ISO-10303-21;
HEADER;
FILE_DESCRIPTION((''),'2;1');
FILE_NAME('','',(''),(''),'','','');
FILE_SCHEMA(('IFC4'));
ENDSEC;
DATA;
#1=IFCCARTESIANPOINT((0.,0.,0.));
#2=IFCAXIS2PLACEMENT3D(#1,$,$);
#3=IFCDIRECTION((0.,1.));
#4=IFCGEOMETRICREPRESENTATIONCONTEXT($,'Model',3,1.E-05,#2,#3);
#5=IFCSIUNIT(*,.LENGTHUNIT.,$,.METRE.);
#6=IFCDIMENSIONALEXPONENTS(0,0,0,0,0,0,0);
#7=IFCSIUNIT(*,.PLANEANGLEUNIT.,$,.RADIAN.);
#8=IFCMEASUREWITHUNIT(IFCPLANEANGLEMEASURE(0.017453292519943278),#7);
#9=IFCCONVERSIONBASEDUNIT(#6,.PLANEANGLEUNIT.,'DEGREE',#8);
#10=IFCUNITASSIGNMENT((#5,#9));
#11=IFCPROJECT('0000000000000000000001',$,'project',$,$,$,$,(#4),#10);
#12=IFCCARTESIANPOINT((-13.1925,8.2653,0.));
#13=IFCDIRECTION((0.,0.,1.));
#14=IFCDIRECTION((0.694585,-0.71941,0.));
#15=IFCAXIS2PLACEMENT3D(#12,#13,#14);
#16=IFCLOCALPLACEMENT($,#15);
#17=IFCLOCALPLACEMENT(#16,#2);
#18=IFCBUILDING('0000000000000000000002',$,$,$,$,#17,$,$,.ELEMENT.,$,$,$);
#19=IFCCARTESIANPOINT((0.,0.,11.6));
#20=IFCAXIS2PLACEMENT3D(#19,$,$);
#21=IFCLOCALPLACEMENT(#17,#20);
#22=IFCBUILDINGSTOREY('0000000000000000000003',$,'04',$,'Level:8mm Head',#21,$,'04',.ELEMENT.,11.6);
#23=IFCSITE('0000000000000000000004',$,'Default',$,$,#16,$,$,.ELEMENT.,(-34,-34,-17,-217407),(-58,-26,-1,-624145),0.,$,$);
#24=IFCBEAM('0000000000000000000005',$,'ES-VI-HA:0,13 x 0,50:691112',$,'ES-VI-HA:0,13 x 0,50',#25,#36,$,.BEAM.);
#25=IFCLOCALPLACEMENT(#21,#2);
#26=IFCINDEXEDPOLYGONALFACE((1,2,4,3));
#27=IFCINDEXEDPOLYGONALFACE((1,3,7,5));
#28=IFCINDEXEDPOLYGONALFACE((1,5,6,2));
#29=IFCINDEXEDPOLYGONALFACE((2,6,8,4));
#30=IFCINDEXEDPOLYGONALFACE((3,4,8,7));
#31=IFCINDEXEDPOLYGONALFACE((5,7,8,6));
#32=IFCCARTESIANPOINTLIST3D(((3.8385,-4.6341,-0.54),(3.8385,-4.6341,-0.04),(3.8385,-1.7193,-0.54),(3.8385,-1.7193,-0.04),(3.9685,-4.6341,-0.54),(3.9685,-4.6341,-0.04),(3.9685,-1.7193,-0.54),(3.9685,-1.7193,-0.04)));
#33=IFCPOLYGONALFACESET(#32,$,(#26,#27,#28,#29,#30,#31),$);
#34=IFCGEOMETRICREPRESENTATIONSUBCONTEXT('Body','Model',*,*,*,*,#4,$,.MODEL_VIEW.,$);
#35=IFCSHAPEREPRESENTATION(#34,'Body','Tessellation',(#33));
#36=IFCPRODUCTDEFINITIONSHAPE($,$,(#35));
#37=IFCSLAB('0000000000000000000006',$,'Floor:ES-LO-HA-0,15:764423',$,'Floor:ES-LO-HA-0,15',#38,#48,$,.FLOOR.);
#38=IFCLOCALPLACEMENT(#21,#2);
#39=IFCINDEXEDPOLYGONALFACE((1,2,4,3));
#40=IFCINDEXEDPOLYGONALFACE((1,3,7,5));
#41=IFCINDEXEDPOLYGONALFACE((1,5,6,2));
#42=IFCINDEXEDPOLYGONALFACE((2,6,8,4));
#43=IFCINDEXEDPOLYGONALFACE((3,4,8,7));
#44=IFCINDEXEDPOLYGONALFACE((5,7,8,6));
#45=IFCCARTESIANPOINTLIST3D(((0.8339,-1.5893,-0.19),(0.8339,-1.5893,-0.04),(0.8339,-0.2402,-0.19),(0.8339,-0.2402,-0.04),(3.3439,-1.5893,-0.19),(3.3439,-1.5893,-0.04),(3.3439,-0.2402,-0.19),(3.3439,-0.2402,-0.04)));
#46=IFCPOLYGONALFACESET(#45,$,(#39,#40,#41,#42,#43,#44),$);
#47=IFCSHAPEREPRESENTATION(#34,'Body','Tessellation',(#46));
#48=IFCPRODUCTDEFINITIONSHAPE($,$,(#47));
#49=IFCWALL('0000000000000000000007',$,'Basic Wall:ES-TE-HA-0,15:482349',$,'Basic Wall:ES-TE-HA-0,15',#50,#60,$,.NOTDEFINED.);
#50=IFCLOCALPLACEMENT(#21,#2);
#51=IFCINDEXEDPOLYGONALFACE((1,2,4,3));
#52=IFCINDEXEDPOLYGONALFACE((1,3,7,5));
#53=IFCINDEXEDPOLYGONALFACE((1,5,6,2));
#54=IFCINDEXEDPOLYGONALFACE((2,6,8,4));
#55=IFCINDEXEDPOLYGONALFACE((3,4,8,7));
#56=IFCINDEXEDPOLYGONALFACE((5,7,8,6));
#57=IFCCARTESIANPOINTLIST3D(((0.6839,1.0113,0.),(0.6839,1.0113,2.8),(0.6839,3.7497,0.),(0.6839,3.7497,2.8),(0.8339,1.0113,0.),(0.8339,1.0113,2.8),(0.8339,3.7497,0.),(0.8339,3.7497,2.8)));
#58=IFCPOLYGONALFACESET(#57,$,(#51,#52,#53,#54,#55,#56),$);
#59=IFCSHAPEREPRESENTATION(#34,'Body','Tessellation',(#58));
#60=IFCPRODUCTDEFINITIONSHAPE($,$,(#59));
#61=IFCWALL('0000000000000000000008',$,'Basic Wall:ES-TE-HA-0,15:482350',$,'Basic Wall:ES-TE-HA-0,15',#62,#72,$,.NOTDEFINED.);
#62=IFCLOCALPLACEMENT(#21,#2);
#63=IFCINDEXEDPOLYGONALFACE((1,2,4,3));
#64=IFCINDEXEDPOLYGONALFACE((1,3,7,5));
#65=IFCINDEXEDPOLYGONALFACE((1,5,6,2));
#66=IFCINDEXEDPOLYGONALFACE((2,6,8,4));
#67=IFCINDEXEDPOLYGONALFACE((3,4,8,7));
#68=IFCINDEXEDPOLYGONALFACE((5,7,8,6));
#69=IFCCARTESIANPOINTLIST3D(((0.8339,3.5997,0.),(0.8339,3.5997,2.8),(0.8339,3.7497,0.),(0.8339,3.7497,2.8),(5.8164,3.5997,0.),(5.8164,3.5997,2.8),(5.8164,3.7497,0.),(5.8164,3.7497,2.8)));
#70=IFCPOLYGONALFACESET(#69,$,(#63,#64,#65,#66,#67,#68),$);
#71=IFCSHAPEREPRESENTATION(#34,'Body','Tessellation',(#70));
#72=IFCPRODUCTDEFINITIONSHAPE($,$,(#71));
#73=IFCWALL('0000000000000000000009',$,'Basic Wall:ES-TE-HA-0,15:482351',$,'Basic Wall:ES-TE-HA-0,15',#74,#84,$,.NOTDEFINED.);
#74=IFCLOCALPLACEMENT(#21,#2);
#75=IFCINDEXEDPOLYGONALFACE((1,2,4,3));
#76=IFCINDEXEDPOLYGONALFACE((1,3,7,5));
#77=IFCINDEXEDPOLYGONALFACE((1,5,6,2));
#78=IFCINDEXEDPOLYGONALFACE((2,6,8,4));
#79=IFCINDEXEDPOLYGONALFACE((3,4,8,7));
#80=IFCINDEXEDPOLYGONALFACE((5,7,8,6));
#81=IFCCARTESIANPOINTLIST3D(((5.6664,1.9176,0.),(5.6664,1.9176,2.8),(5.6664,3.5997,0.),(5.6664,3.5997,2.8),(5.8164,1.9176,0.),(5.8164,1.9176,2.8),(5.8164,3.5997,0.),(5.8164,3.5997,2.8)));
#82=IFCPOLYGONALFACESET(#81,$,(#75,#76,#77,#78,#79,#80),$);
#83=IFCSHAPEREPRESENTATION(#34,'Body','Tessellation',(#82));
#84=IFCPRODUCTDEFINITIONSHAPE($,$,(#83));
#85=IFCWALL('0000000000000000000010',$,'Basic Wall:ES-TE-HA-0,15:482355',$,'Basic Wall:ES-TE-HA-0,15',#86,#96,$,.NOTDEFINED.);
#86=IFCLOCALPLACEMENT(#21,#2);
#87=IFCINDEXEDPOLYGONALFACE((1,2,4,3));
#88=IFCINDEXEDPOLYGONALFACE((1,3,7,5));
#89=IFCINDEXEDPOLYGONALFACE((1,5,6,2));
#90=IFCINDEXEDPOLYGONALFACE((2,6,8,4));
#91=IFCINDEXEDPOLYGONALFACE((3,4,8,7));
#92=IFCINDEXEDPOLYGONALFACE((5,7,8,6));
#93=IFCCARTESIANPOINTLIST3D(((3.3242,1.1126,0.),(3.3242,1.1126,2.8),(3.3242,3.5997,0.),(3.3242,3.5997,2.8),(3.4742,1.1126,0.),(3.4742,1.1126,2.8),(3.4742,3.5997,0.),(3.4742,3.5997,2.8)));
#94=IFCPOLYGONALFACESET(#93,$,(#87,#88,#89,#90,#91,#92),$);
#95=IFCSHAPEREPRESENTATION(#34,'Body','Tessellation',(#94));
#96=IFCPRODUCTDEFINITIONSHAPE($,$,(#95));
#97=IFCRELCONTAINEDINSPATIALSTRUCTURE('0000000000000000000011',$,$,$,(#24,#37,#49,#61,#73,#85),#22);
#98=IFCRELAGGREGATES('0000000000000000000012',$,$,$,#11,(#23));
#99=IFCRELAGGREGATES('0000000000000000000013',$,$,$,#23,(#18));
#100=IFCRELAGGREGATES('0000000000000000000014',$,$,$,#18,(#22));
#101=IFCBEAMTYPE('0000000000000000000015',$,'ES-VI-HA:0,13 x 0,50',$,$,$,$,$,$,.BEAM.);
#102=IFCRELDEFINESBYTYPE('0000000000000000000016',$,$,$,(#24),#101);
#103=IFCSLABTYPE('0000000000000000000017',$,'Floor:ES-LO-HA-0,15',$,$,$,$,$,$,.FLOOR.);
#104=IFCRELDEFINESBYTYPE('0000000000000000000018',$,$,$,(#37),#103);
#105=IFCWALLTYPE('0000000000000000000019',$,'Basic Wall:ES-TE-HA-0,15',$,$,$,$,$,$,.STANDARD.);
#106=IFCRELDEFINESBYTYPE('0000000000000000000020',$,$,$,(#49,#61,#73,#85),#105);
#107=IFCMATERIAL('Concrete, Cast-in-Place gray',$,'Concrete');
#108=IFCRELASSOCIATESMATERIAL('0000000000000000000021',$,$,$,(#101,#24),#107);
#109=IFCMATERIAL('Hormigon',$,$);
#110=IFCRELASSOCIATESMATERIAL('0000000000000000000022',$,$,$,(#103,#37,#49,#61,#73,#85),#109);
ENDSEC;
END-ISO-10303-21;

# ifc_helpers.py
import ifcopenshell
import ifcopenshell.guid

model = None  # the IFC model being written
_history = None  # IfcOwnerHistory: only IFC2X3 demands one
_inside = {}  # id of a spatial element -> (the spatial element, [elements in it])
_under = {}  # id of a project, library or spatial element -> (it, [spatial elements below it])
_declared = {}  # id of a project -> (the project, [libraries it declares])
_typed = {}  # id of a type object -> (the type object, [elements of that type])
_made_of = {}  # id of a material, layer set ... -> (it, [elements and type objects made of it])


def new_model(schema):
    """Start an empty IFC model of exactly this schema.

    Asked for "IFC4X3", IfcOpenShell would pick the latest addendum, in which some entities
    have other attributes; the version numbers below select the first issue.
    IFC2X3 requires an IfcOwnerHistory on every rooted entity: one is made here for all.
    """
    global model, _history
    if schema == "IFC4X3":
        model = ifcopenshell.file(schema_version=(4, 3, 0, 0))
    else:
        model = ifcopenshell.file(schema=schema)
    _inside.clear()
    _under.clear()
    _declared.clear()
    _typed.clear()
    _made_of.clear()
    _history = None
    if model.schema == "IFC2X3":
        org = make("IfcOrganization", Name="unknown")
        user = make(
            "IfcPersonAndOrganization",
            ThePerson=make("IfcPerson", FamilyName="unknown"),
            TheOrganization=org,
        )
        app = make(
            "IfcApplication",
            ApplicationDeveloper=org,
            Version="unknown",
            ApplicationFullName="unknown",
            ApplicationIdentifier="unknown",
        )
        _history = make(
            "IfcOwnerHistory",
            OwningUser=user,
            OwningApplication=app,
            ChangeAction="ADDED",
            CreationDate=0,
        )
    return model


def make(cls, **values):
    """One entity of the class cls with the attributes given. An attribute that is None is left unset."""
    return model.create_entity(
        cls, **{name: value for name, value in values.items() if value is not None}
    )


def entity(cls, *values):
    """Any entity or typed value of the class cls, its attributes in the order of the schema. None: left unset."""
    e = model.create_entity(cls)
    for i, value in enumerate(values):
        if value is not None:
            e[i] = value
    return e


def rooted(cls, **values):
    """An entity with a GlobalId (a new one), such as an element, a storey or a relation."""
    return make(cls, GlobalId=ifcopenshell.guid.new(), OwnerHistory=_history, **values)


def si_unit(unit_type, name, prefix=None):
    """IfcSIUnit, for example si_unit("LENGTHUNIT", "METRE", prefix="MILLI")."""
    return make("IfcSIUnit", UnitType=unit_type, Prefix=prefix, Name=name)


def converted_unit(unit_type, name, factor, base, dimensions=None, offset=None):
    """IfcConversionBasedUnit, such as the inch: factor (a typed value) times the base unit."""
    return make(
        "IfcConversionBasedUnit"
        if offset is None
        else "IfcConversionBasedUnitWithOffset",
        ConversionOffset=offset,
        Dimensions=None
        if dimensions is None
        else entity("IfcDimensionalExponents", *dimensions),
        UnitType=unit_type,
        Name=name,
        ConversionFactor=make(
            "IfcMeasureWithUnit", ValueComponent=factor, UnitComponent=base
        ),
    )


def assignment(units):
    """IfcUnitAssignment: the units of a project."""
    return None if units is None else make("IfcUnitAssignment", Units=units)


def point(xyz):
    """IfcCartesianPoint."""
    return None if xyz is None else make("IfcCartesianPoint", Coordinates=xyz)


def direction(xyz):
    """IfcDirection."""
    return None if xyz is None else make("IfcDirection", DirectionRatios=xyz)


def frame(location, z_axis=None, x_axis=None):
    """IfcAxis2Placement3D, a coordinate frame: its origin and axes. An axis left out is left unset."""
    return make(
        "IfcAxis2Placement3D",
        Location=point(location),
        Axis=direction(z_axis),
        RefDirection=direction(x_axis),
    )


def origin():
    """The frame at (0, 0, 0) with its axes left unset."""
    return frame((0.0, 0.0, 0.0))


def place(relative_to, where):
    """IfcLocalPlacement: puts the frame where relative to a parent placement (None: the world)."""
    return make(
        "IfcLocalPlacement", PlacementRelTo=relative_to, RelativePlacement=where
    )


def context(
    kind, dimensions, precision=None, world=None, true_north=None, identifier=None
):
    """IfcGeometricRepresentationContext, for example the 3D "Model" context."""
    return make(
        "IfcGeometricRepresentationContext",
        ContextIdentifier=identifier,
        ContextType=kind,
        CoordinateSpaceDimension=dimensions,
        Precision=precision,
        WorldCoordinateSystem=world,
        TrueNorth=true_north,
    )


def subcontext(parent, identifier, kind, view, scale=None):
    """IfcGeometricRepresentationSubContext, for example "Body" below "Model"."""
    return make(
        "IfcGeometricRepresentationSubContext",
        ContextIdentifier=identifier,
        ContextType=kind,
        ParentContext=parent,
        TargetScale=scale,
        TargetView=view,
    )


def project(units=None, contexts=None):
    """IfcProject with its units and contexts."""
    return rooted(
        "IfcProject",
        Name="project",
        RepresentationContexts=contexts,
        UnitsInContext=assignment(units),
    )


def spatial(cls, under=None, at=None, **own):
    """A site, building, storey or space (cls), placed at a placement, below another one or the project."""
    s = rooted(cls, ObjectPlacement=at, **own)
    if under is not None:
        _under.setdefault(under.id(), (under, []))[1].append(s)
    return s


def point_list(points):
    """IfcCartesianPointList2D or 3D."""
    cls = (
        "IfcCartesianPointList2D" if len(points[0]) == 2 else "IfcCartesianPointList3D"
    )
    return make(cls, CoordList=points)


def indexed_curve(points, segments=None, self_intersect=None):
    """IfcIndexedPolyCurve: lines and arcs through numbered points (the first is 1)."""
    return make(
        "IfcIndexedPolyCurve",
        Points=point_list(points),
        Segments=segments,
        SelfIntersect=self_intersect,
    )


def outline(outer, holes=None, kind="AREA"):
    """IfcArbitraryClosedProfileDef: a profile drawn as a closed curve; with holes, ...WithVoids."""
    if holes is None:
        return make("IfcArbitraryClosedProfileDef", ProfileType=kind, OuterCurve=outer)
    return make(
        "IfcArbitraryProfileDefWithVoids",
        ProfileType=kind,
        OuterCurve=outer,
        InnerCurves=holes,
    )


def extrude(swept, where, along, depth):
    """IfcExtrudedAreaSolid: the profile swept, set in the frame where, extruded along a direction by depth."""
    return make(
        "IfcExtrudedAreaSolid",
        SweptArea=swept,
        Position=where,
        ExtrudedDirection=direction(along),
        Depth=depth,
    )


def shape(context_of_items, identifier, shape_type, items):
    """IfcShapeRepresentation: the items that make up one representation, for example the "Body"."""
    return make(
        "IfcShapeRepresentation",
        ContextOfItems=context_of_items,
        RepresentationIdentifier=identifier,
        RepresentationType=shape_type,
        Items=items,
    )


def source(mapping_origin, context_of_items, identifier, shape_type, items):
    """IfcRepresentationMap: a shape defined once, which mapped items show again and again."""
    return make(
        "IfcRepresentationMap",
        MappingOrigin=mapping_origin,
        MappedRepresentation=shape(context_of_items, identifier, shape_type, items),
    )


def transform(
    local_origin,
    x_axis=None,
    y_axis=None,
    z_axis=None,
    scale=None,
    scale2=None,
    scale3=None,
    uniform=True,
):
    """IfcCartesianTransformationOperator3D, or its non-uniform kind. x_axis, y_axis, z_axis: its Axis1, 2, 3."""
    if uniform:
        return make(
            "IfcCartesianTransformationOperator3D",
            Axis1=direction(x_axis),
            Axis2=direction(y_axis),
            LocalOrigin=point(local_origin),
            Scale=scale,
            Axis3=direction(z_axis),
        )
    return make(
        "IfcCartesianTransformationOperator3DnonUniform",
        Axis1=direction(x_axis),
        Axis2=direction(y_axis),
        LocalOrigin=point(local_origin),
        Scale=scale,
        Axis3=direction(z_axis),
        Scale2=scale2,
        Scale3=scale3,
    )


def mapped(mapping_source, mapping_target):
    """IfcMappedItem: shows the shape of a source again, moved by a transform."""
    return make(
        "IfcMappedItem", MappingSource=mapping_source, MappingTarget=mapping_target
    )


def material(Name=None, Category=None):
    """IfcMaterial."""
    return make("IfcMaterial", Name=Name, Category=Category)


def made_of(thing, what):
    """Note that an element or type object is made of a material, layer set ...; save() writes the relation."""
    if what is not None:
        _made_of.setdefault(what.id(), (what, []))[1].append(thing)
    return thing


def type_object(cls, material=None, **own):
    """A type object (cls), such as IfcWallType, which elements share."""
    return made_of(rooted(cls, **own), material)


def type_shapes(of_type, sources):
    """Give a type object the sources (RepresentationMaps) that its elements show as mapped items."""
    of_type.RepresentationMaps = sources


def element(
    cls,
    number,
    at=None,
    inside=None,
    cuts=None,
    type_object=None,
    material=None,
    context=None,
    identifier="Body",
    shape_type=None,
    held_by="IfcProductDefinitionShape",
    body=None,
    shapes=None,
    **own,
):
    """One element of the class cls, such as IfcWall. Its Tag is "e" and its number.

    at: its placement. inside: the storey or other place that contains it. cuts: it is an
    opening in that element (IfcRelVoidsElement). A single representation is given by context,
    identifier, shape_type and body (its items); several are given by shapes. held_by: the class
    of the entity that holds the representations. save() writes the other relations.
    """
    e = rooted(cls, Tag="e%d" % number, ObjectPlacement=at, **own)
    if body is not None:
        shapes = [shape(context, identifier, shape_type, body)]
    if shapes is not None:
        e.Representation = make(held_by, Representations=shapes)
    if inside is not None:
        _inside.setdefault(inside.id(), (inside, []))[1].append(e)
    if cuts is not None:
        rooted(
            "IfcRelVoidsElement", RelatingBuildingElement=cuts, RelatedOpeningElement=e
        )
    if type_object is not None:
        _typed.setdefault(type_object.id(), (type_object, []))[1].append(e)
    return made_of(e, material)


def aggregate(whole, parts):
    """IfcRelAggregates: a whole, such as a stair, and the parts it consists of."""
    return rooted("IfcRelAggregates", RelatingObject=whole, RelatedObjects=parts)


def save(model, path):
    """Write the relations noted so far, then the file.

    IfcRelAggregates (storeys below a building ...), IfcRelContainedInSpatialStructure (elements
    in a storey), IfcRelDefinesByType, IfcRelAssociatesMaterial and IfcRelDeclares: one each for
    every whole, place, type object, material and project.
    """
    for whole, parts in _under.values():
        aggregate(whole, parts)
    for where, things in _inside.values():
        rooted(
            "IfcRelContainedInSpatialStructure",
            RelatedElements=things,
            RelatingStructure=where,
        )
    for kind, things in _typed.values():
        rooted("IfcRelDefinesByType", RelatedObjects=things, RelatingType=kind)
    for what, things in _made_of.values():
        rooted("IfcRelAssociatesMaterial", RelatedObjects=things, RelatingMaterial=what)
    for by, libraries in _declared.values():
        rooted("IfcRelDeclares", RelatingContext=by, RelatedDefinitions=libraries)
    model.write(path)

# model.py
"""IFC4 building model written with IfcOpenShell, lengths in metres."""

from ifc_helpers import new_model, entity, si_unit, converted_unit, direction, frame, origin, place, context, subcontext, project, spatial, indexed_curve, outline, extrude, source, transform, mapped, material, type_object, type_shapes, element, save


model = new_model("IFC4")

# Units and contexts
model_context = context("Model", 3, precision=1e-05, world=origin(), true_north=direction((0.0, 1.0)))
body_context = subcontext(model_context, "Body", "Model", "MODEL_VIEW")
ifc_project = project(units=[si_unit("LENGTHUNIT", "METRE"), converted_unit("PLANEANGLEUNIT", "DEGREE", entity("IfcPlaneAngleMeasure", 0.017453292519943278), si_unit("PLANEANGLEUNIT", "RADIAN"), dimensions=[0, 0, 0, 0, 0, 0, 0])], contexts=[model_context])

# Site, building, storey
site_placement = place(None, frame((-13.1925, 8.2653, 0.0), z_axis=(0.0, 0.0, 1.0), x_axis=(0.694585, -0.71941, 0.0)))
site = spatial("IfcSite", under=ifc_project, at=site_placement, Name="Default", CompositionType="ELEMENT", RefLatitude=(-34, -34, -17, -217407), RefLongitude=(-58, -26, -1, -624145), RefElevation=0.0)
building_placement = place(site_placement, origin())
building = spatial("IfcBuilding", under=site, at=building_placement, CompositionType="ELEMENT")
storey_placement = place(building_placement, frame((0.0, 0.0, 11.6)))
storey = spatial("IfcBuildingStorey", under=building, at=storey_placement, Name="04", ObjectType="Level:8mm Head", LongName="04", CompositionType="ELEMENT", Elevation=11.6)

# Beam
ifc_material_1 = material(Name="Concrete, Cast-in-Place gray", Category="Concrete")
beam_type = type_object("IfcBeamType", Name="ES-VI-HA:0,13 x 0,50", PredefinedType="BEAM", material=ifc_material_1)
shared_shape = source(origin(), body_context, "Body", "SweptSolid", [
    extrude(outline(indexed_curve([(-0.065, -0.25), (0.065, -0.25), (0.065, 0.25), (-0.065, 0.25), (-0.065, -0.25)], self_intersect=False)), frame((3.9035, -4.6341, 11.31), z_axis=(0.0, 1.0, 0.0), x_axis=(-1.0, 0.0, 0.0)), (0.0, 0.0, 1.0), 2.9148),
])
type_shapes(beam_type, [shared_shape])
beam_placement = place(storey_placement, frame((0.0, 0.0, -11.6)))
element("IfcBeam", 1, at=beam_placement, inside=storey, type_object=beam_type, material=ifc_material_1, Name="ES-VI-HA:0,13 x 0,50:691112", ObjectType="ES-VI-HA:0,13 x 0,50", PredefinedType="BEAM", context=body_context, shape_type="MappedRepresentation", body=[
    mapped(shared_shape, transform((0.0, 0.0, 0.0), scale=1.0)),
])

# Shared definitions
ifc_material_2 = material(Name="Hormigon")
slab_type_1 = type_object("IfcSlabType", Name="Floor:ES-LO-HA-0,15", PredefinedType="FLOOR", material=ifc_material_2)

# Slab
slab_1_placement = place(storey_placement, origin())
element("IfcSlab", 2, at=slab_1_placement, inside=storey, type_object=slab_type_1, material=ifc_material_2, Name="Floor:ES-LO-HA-0,15:764423", ObjectType="Floor:ES-LO-HA-0,15", PredefinedType="FLOOR", context=body_context, shape_type="SweptSolid", body=[
    extrude(outline(indexed_curve([(-0.6746, -1.255), (0.6746, -1.255), (0.6746, 1.255), (-0.6746, 1.255), (-0.6746, -1.255)], self_intersect=False)), frame((2.0889, -0.9147, -0.04), z_axis=(0.0, 0.0, -1.0), x_axis=(0.0, 1.0, 0.0)), (0.0, 0.0, 1.0), 0.15),
])

# Walls
wall_type = type_object("IfcWallType", Name="Basic Wall:ES-TE-HA-0,15", PredefinedType="STANDARD")
wall_1_placement = place(storey_placement, frame((0.7589, 1.0113, 0.0), z_axis=(0.0, 0.0, 1.0), x_axis=(0.0, 1.0, 0.0)))
element("IfcWall", 3, at=wall_1_placement, inside=storey, type_object=wall_type, material=ifc_material_2, Name="Basic Wall:ES-TE-HA-0,15:482349", ObjectType="Basic Wall:ES-TE-HA-0,15", PredefinedType="NOTDEFINED", context=body_context, shape_type="SweptSolid", body=[
    extrude(outline(indexed_curve([(2.7384, 0.075), (0.0, 0.075), (0.0, -0.075), (2.7384, -0.075), (2.7384, 0.075)], self_intersect=False)), origin(), (0.0, 0.0, 1.0), 2.8),
])
wall_2_placement = place(storey_placement, frame((0.8339, 3.6747, 0.0)))
element("IfcWall", 4, at=wall_2_placement, inside=storey, type_object=wall_type, material=ifc_material_2, Name="Basic Wall:ES-TE-HA-0,15:482350", ObjectType="Basic Wall:ES-TE-HA-0,15", PredefinedType="NOTDEFINED", context=body_context, shape_type="SweptSolid", body=[
    extrude(outline(indexed_curve([(4.9825, 0.075), (0.0, 0.075), (0.0, -0.075), (4.9825, -0.075), (4.9825, 0.075)], self_intersect=False)), origin(), (0.0, 0.0, 1.0), 2.8),
])
wall_3_placement = place(storey_placement, frame((5.7414, 1.9176, 0.0), z_axis=(0.0, 0.0, 1.0), x_axis=(0.0, 1.0, 0.0)))
element("IfcWall", 5, at=wall_3_placement, inside=storey, type_object=wall_type, material=ifc_material_2, Name="Basic Wall:ES-TE-HA-0,15:482351", ObjectType="Basic Wall:ES-TE-HA-0,15", PredefinedType="NOTDEFINED", context=body_context, shape_type="SweptSolid", body=[
    extrude(outline(indexed_curve([(1.682, 0.075), (0.0, 0.075), (0.0, -0.075), (1.682, -0.075), (1.682, 0.075)], self_intersect=False)), origin(), (0.0, 0.0, 1.0), 2.8),
])
wall_4_placement = place(storey_placement, frame((3.3992, 3.5997, 0.0), z_axis=(0.0, 0.0, 1.0), x_axis=(0.0, -1.0, 0.0)))
element("IfcWall", 6, at=wall_4_placement, inside=storey, type_object=wall_type, material=ifc_material_2, Name="Basic Wall:ES-TE-HA-0,15:482355", ObjectType="Basic Wall:ES-TE-HA-0,15", PredefinedType="NOTDEFINED", context=body_context, shape_type="SweptSolid", body=[
    extrude(outline(indexed_curve([(2.487, 0.075), (0.0, 0.075), (0.0, -0.075), (2.487, -0.075), (2.487, 0.075)], self_intersect=False)), origin(), (0.0, 0.0, 1.0), 2.8),
])

save(model, "model.ifc")
